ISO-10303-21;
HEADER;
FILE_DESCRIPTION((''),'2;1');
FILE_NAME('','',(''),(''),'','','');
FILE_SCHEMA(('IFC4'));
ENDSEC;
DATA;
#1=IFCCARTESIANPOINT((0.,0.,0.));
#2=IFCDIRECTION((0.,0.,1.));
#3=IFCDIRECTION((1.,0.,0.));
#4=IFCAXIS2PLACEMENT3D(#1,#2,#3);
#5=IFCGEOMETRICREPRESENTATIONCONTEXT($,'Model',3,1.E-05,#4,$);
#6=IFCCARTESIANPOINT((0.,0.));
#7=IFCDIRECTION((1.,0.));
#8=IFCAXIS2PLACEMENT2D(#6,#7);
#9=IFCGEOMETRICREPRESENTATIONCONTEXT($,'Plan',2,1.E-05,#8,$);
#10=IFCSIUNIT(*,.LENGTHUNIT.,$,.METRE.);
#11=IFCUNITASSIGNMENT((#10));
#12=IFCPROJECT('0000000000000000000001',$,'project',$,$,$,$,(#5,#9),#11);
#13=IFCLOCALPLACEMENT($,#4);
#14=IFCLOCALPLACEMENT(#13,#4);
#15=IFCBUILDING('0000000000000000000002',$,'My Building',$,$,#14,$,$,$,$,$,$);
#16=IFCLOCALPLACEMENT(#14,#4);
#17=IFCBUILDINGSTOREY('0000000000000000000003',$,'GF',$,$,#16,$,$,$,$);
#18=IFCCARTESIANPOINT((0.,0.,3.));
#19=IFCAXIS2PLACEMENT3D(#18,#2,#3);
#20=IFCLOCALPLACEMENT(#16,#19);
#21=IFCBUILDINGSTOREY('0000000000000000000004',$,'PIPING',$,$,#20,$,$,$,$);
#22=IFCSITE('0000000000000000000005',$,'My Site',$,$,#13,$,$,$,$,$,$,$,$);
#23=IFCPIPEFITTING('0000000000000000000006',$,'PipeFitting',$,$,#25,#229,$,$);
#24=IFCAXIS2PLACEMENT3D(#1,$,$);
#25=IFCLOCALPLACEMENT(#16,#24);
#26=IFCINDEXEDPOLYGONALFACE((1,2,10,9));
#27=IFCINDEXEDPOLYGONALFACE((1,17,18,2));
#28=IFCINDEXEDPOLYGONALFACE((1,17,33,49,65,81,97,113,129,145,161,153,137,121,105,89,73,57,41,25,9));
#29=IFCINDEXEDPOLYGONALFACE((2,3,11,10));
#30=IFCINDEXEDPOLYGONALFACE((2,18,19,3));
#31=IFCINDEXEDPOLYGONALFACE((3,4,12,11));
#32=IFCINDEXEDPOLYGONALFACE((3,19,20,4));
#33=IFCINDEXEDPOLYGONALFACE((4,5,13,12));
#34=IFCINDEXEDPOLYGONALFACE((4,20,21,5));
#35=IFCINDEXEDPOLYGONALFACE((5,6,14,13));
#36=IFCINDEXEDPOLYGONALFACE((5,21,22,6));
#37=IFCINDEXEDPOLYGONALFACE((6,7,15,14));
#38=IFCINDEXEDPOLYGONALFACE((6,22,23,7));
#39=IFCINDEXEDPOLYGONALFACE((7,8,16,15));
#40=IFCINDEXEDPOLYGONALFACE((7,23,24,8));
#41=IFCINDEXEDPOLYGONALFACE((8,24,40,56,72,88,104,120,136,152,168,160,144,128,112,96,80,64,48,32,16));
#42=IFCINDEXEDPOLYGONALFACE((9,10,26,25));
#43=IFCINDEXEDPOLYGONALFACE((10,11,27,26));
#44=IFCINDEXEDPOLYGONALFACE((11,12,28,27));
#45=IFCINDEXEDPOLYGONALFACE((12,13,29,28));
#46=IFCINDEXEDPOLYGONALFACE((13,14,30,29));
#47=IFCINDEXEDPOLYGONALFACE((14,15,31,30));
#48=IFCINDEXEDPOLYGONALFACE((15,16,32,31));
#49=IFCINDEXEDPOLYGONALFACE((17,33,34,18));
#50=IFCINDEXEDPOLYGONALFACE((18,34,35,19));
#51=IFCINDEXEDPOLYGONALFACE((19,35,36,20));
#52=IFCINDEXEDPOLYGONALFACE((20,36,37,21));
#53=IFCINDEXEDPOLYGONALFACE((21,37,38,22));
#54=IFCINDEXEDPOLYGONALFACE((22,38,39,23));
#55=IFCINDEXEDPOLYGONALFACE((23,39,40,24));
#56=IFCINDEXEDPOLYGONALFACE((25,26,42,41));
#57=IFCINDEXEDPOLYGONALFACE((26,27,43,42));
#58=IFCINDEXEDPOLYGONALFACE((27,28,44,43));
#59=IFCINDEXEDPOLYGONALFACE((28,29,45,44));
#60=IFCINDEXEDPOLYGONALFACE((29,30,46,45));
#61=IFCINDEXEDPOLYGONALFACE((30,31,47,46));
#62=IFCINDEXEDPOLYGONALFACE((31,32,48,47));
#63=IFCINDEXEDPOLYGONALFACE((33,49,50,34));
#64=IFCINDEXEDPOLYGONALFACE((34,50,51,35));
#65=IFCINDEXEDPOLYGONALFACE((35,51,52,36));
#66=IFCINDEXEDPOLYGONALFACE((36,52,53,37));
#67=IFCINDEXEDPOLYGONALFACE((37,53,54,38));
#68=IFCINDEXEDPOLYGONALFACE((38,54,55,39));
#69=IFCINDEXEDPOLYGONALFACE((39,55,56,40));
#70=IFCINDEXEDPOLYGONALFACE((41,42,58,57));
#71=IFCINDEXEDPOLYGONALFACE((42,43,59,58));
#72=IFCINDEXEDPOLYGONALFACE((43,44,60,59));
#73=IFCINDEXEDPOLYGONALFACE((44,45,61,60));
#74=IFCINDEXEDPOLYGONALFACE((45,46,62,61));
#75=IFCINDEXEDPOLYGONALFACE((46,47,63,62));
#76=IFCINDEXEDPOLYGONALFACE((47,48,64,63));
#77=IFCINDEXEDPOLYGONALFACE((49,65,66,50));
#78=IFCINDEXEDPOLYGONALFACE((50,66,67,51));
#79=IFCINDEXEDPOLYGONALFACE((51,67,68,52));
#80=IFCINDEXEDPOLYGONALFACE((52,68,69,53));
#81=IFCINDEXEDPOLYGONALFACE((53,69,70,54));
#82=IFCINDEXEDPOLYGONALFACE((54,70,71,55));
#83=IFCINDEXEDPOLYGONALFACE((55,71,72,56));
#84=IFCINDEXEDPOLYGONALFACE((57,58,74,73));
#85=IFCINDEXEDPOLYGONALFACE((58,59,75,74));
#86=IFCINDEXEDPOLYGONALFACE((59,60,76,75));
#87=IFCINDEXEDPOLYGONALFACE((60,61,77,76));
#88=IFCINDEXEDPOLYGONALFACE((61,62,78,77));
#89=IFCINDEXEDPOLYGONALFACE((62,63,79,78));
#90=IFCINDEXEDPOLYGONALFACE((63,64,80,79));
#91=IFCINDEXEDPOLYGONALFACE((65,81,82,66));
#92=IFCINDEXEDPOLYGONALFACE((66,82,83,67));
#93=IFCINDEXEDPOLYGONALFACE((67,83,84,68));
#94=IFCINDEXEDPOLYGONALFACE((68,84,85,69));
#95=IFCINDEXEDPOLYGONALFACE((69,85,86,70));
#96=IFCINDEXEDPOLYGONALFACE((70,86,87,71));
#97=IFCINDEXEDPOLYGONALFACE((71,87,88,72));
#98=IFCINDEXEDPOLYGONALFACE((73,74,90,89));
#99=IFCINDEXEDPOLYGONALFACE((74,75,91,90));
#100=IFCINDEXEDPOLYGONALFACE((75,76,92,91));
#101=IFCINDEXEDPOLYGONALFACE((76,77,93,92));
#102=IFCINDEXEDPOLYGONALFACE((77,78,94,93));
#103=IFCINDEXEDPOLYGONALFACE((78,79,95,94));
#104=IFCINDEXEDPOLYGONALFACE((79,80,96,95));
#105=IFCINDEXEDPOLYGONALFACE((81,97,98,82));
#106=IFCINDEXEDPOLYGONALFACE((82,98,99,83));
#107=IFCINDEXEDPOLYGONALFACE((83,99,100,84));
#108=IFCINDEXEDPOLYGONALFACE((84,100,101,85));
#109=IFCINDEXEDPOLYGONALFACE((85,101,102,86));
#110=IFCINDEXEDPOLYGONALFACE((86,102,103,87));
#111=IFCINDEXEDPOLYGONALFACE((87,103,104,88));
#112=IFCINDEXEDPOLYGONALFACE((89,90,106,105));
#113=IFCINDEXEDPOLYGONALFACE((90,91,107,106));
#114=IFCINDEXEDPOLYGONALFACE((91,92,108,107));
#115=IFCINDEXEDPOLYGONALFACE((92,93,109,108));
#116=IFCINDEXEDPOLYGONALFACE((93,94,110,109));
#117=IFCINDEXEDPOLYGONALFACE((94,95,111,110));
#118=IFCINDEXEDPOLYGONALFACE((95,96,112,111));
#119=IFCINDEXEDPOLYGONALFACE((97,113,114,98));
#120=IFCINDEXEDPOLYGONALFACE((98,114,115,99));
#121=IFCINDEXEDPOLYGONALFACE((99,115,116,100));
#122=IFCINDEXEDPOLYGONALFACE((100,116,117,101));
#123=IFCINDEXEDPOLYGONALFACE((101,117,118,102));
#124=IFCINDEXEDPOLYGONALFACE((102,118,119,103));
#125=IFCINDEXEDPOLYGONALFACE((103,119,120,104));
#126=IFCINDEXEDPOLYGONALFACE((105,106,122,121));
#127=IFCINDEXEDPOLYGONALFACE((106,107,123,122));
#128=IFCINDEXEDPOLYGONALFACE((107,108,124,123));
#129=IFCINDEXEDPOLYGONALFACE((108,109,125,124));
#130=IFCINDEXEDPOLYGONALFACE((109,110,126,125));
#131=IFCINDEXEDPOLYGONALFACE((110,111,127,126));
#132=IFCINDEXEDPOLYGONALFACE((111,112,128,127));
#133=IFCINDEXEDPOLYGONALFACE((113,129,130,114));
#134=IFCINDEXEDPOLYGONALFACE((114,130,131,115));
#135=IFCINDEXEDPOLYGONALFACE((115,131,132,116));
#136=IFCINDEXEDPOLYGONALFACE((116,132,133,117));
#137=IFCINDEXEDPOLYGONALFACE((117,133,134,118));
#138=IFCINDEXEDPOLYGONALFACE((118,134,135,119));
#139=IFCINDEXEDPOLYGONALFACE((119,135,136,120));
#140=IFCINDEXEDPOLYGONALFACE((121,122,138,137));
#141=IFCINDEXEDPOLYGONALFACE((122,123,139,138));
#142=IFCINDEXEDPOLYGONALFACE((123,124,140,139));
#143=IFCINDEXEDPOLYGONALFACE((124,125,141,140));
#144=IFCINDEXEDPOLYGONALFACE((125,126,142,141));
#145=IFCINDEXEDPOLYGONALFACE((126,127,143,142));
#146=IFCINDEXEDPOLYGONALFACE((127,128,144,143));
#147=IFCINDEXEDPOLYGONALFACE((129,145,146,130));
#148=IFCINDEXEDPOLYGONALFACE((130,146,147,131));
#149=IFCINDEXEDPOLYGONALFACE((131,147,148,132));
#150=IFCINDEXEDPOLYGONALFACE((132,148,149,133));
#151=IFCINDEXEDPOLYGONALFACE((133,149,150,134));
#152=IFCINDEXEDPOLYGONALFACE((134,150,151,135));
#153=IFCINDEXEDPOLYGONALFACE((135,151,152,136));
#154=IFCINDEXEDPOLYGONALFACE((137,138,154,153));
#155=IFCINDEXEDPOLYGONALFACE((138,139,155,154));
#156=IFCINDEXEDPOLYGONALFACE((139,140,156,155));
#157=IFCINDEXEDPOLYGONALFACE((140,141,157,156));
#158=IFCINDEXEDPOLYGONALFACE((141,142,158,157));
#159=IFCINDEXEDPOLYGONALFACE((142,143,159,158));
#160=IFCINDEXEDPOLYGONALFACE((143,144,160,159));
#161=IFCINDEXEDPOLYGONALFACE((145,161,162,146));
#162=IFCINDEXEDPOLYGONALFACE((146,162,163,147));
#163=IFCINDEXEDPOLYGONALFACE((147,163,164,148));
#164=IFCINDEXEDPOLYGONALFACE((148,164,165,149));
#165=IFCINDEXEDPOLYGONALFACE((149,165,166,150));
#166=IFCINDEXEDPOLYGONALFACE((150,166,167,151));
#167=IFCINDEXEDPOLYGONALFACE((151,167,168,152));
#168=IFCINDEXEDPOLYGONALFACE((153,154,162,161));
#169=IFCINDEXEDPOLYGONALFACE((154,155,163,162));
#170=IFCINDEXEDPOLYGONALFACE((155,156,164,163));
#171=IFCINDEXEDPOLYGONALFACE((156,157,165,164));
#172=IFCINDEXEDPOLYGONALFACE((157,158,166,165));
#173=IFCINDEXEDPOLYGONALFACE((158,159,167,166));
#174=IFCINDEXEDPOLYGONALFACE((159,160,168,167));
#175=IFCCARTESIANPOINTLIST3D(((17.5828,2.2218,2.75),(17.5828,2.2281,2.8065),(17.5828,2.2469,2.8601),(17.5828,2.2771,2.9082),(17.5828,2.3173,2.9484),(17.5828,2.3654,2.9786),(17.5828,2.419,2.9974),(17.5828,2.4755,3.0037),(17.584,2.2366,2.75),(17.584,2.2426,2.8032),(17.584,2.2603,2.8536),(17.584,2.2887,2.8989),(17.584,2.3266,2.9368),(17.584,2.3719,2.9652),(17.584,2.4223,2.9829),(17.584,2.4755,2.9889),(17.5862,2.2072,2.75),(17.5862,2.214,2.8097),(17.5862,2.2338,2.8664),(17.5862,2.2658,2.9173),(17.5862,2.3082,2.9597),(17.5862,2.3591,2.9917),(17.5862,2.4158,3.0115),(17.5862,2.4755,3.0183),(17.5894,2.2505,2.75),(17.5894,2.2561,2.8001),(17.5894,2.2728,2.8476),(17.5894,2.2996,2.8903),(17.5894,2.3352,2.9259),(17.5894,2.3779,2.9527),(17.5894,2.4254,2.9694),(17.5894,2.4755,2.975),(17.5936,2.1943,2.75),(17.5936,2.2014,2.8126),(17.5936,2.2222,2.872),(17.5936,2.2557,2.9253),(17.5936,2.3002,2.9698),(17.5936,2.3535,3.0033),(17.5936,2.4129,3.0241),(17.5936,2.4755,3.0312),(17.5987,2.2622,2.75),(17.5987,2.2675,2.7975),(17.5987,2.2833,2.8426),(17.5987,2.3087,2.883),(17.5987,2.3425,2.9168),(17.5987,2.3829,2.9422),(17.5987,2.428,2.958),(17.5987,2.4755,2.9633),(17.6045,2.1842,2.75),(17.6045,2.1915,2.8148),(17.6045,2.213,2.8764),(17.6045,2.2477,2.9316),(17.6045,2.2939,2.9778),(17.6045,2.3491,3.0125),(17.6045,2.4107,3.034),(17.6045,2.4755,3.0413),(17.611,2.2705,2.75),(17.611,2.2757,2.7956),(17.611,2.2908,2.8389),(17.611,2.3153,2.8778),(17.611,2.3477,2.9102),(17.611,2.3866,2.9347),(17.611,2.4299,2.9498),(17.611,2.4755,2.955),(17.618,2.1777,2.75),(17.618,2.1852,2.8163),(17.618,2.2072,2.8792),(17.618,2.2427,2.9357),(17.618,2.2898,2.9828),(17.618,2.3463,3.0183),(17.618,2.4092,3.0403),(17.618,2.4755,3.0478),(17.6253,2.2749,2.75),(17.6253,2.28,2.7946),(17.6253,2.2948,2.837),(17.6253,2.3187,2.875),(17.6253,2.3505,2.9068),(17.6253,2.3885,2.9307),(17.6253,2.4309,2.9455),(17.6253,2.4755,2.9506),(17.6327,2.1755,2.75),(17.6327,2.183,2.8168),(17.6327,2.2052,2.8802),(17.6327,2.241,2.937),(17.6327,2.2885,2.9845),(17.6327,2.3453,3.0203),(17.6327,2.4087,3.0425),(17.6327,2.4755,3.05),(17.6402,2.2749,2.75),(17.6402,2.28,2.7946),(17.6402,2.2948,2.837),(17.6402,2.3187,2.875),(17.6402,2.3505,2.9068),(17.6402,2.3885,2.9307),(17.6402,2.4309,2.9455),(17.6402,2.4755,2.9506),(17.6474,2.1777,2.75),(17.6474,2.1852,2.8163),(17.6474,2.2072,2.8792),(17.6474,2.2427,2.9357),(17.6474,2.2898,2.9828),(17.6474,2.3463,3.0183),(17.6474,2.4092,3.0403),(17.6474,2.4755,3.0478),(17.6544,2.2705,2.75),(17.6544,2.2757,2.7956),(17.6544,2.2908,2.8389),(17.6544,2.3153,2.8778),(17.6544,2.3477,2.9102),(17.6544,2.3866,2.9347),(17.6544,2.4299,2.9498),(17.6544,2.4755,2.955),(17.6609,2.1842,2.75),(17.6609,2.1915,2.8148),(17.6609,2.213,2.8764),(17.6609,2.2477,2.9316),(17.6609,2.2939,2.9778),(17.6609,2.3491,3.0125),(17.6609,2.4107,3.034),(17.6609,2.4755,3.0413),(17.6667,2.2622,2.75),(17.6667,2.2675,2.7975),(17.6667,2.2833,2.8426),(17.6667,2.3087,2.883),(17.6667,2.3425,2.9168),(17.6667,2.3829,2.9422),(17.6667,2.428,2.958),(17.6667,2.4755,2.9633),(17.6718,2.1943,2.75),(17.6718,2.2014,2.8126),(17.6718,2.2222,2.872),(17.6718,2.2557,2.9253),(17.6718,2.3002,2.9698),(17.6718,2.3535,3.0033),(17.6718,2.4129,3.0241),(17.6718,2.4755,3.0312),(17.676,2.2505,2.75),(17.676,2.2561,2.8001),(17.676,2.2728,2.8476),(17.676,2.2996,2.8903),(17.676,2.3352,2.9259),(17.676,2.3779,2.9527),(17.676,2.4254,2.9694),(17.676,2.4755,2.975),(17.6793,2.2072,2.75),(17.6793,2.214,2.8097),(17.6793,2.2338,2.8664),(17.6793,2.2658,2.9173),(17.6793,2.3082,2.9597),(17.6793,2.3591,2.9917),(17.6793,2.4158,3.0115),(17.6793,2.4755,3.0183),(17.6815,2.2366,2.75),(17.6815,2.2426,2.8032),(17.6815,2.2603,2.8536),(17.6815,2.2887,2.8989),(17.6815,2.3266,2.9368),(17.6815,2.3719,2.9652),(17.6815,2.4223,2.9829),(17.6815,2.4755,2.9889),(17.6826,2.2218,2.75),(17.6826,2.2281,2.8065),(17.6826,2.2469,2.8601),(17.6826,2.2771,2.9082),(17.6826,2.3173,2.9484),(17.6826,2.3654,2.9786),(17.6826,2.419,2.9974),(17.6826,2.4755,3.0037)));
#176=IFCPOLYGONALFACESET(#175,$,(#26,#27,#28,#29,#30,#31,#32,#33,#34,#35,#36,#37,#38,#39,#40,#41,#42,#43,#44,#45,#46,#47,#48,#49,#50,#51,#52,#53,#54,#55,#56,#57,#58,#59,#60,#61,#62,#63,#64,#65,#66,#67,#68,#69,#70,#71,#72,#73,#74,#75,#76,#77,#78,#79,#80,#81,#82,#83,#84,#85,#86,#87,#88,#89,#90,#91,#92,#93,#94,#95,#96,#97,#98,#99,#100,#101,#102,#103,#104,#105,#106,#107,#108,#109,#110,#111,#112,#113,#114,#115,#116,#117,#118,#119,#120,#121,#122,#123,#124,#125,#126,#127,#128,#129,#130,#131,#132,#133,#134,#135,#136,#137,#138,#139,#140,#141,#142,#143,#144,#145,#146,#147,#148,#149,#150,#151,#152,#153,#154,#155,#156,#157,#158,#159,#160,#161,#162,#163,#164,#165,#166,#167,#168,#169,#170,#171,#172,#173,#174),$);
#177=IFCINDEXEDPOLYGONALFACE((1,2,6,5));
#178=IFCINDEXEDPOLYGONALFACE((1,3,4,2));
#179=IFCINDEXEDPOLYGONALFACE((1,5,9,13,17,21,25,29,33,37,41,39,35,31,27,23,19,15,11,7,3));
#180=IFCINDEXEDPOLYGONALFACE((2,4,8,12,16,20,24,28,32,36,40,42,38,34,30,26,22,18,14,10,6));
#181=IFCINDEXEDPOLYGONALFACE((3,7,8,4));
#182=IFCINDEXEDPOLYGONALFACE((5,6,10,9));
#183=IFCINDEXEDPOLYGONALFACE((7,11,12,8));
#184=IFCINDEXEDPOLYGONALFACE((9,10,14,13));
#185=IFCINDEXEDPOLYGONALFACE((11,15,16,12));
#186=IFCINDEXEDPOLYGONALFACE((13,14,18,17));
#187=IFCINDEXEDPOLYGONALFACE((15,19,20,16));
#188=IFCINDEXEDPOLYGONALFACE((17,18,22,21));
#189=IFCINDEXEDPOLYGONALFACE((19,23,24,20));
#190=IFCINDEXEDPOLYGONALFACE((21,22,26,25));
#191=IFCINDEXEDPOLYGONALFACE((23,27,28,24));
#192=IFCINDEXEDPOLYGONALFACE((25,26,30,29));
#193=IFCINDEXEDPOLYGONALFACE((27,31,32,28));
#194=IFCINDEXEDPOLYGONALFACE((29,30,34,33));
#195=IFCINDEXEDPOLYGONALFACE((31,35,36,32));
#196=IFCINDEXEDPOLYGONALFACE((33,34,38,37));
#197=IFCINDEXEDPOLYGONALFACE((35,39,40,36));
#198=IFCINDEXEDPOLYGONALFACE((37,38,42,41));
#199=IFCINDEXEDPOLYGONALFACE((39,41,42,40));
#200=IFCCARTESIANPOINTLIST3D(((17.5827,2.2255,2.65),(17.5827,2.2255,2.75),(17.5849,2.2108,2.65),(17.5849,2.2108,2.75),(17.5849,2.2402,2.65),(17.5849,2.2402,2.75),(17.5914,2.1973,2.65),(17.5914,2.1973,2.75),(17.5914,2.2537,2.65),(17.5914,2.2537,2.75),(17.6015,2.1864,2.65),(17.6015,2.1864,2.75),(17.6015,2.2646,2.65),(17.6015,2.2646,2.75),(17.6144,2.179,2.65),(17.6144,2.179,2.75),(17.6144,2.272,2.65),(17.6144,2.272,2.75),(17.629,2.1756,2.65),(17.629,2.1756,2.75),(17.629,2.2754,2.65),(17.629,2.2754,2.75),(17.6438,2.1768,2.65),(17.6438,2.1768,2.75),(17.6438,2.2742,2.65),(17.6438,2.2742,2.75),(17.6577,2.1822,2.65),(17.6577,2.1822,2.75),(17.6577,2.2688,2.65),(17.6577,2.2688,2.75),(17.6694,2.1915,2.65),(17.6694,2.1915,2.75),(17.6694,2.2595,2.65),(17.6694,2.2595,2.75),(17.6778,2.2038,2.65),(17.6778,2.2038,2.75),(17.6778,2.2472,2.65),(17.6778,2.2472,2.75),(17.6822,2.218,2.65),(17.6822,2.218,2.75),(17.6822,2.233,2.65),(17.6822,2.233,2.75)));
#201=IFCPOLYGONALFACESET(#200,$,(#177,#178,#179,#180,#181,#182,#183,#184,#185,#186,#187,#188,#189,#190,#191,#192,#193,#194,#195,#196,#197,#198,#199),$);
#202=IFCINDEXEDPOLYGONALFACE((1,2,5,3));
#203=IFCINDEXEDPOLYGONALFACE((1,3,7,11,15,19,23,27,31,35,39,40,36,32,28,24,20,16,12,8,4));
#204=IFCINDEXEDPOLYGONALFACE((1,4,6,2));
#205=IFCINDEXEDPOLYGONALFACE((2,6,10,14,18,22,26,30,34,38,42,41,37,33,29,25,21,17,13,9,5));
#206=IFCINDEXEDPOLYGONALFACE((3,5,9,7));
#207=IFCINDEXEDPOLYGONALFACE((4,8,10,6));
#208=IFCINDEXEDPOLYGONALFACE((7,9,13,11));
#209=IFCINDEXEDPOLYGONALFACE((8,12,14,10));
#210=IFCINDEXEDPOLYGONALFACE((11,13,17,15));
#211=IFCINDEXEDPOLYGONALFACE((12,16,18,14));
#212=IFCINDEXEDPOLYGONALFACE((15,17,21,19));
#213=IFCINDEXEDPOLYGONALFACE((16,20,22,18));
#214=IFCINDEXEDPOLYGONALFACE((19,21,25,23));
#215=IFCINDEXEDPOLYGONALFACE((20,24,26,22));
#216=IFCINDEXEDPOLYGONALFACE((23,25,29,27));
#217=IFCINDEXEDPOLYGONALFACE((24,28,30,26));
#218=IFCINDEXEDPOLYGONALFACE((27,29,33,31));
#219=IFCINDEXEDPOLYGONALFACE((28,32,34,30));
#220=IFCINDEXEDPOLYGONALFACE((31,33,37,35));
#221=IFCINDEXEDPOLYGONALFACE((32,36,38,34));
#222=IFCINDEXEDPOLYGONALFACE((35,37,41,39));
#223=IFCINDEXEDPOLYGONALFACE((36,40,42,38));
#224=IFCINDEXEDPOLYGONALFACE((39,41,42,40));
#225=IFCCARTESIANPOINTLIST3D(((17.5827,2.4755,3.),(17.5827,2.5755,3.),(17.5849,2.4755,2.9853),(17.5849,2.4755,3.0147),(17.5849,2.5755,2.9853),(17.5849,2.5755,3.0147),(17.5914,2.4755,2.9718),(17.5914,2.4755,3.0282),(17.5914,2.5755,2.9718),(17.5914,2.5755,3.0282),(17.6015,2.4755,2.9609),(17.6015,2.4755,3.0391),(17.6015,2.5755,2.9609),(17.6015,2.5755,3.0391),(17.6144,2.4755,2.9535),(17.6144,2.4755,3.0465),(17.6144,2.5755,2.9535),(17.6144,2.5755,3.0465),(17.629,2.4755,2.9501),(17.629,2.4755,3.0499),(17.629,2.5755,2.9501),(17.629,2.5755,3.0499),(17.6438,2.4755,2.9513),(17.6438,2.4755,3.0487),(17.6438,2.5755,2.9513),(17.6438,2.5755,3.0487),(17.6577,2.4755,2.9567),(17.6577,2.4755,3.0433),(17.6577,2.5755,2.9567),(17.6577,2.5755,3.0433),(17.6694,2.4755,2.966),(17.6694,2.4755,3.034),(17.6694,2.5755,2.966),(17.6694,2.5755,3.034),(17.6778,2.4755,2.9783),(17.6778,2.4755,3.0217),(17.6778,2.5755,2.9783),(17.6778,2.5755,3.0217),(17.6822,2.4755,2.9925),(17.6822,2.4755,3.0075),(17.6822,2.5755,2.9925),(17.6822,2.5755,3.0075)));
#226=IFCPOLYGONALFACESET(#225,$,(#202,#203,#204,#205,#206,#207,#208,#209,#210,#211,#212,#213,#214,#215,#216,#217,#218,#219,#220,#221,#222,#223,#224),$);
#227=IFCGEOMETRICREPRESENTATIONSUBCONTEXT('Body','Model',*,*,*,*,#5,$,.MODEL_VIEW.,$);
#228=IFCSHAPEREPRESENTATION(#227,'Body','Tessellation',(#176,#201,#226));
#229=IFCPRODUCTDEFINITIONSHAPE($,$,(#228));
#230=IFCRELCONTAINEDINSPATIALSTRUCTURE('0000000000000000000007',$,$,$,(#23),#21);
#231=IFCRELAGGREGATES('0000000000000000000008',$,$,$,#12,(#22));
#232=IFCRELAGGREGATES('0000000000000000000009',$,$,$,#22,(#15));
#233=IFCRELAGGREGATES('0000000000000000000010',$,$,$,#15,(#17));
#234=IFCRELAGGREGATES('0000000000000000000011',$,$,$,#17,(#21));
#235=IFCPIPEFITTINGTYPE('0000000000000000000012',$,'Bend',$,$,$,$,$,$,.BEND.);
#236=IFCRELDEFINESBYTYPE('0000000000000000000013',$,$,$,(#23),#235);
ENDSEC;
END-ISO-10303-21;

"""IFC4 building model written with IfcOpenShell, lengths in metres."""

from ifc_helpers import new_model, entity, si_unit, frame, origin_with_axes, origin_2d_with_axis, place, context, subcontext, project, spatial, circle, extrude, source, transform, mapped, type_object, type_shapes, element, save


model = new_model("IFC4")

# Units and contexts
model_context = context("Model", 3, precision=1e-05, world=origin_with_axes())
plan_context = context("Plan", 2, precision=1e-05, world=origin_2d_with_axis())
body_context = subcontext(model_context, "Body", "Model", "MODEL_VIEW")
ifc_project = project(units=[si_unit("LENGTHUNIT", "METRE")], contexts=[model_context, plan_context])

# Site, building, storeys
site_placement = place(None, origin_with_axes())
site = spatial("IfcSite", under=ifc_project, at=site_placement, Name="My Site")
building_placement = place(site_placement, origin_with_axes())
building = spatial("IfcBuilding", under=site, at=building_placement, Name="My Building")
storey_1_placement = place(building_placement, origin_with_axes())
storey_1 = spatial("IfcBuildingStorey", under=building, at=storey_1_placement, Name="GF")
storey_2_placement = place(storey_1_placement, frame((0.0, 0.0, 3.0), z_axis=(0.0, 0.0, 1.0), x_axis=(1.0, 0.0, 0.0)))
storey_2 = spatial("IfcBuildingStorey", under=storey_1, at=storey_2_placement, Name="PIPING")

# Pipe fitting
pipe_fitting_type = type_object("IfcPipeFittingType", Name="Bend", PredefinedType="BEND")
shared_shape = source(origin_with_axes(), body_context, "Body", "SolidModel", [
    entity("IfcSweptDiskSolid", entity("IfcIndexedPolyCurve", entity("IfcCartesianPointList3D", [[0.0, 0.0, -0.1], [0.0, 0.0732, -0.2768], [0.0, 0.25, -0.35]]), [entity("IfcArcIndex", [1, 2, 3])]), 0.05),
    extrude(circle(Radius=0.05), origin_with_axes(), (0.0, 0.0, -1.0), 0.1),
    extrude(circle(Radius=0.05), frame((0.0, 0.25, -0.35), z_axis=(0.0, 1.0, 0.0), x_axis=(1.0, 0.0, 0.0)), (0.0, 0.0, 1.0), 0.1),
])
type_shapes(pipe_fitting_type, [shared_shape])
for number, where, z_axis, x_axis, name in (
    (1, (17.6327, 2.2255, -0.35), (0.0, 0.0, -1.0), (-1.0, 0.0, 0.0), "PipeFitting"),
):
    element("IfcPipeFitting", number, at=place(storey_2_placement, frame(where, z_axis=z_axis, x_axis=x_axis)), inside=storey_2, type_object=pipe_fitting_type, Name=name, context=body_context, shape_type="MappedRepresentation", body=[
        mapped(shared_shape, transform((0.0, 0.0, 0.0), x_axis=(1.0, 0.0, 0.0), y_axis=(0.0, 1.0, 0.0), z_axis=(0.0, 0.0, 1.0), scale=1.0)),
    ])

save(model, "model.ifc")
